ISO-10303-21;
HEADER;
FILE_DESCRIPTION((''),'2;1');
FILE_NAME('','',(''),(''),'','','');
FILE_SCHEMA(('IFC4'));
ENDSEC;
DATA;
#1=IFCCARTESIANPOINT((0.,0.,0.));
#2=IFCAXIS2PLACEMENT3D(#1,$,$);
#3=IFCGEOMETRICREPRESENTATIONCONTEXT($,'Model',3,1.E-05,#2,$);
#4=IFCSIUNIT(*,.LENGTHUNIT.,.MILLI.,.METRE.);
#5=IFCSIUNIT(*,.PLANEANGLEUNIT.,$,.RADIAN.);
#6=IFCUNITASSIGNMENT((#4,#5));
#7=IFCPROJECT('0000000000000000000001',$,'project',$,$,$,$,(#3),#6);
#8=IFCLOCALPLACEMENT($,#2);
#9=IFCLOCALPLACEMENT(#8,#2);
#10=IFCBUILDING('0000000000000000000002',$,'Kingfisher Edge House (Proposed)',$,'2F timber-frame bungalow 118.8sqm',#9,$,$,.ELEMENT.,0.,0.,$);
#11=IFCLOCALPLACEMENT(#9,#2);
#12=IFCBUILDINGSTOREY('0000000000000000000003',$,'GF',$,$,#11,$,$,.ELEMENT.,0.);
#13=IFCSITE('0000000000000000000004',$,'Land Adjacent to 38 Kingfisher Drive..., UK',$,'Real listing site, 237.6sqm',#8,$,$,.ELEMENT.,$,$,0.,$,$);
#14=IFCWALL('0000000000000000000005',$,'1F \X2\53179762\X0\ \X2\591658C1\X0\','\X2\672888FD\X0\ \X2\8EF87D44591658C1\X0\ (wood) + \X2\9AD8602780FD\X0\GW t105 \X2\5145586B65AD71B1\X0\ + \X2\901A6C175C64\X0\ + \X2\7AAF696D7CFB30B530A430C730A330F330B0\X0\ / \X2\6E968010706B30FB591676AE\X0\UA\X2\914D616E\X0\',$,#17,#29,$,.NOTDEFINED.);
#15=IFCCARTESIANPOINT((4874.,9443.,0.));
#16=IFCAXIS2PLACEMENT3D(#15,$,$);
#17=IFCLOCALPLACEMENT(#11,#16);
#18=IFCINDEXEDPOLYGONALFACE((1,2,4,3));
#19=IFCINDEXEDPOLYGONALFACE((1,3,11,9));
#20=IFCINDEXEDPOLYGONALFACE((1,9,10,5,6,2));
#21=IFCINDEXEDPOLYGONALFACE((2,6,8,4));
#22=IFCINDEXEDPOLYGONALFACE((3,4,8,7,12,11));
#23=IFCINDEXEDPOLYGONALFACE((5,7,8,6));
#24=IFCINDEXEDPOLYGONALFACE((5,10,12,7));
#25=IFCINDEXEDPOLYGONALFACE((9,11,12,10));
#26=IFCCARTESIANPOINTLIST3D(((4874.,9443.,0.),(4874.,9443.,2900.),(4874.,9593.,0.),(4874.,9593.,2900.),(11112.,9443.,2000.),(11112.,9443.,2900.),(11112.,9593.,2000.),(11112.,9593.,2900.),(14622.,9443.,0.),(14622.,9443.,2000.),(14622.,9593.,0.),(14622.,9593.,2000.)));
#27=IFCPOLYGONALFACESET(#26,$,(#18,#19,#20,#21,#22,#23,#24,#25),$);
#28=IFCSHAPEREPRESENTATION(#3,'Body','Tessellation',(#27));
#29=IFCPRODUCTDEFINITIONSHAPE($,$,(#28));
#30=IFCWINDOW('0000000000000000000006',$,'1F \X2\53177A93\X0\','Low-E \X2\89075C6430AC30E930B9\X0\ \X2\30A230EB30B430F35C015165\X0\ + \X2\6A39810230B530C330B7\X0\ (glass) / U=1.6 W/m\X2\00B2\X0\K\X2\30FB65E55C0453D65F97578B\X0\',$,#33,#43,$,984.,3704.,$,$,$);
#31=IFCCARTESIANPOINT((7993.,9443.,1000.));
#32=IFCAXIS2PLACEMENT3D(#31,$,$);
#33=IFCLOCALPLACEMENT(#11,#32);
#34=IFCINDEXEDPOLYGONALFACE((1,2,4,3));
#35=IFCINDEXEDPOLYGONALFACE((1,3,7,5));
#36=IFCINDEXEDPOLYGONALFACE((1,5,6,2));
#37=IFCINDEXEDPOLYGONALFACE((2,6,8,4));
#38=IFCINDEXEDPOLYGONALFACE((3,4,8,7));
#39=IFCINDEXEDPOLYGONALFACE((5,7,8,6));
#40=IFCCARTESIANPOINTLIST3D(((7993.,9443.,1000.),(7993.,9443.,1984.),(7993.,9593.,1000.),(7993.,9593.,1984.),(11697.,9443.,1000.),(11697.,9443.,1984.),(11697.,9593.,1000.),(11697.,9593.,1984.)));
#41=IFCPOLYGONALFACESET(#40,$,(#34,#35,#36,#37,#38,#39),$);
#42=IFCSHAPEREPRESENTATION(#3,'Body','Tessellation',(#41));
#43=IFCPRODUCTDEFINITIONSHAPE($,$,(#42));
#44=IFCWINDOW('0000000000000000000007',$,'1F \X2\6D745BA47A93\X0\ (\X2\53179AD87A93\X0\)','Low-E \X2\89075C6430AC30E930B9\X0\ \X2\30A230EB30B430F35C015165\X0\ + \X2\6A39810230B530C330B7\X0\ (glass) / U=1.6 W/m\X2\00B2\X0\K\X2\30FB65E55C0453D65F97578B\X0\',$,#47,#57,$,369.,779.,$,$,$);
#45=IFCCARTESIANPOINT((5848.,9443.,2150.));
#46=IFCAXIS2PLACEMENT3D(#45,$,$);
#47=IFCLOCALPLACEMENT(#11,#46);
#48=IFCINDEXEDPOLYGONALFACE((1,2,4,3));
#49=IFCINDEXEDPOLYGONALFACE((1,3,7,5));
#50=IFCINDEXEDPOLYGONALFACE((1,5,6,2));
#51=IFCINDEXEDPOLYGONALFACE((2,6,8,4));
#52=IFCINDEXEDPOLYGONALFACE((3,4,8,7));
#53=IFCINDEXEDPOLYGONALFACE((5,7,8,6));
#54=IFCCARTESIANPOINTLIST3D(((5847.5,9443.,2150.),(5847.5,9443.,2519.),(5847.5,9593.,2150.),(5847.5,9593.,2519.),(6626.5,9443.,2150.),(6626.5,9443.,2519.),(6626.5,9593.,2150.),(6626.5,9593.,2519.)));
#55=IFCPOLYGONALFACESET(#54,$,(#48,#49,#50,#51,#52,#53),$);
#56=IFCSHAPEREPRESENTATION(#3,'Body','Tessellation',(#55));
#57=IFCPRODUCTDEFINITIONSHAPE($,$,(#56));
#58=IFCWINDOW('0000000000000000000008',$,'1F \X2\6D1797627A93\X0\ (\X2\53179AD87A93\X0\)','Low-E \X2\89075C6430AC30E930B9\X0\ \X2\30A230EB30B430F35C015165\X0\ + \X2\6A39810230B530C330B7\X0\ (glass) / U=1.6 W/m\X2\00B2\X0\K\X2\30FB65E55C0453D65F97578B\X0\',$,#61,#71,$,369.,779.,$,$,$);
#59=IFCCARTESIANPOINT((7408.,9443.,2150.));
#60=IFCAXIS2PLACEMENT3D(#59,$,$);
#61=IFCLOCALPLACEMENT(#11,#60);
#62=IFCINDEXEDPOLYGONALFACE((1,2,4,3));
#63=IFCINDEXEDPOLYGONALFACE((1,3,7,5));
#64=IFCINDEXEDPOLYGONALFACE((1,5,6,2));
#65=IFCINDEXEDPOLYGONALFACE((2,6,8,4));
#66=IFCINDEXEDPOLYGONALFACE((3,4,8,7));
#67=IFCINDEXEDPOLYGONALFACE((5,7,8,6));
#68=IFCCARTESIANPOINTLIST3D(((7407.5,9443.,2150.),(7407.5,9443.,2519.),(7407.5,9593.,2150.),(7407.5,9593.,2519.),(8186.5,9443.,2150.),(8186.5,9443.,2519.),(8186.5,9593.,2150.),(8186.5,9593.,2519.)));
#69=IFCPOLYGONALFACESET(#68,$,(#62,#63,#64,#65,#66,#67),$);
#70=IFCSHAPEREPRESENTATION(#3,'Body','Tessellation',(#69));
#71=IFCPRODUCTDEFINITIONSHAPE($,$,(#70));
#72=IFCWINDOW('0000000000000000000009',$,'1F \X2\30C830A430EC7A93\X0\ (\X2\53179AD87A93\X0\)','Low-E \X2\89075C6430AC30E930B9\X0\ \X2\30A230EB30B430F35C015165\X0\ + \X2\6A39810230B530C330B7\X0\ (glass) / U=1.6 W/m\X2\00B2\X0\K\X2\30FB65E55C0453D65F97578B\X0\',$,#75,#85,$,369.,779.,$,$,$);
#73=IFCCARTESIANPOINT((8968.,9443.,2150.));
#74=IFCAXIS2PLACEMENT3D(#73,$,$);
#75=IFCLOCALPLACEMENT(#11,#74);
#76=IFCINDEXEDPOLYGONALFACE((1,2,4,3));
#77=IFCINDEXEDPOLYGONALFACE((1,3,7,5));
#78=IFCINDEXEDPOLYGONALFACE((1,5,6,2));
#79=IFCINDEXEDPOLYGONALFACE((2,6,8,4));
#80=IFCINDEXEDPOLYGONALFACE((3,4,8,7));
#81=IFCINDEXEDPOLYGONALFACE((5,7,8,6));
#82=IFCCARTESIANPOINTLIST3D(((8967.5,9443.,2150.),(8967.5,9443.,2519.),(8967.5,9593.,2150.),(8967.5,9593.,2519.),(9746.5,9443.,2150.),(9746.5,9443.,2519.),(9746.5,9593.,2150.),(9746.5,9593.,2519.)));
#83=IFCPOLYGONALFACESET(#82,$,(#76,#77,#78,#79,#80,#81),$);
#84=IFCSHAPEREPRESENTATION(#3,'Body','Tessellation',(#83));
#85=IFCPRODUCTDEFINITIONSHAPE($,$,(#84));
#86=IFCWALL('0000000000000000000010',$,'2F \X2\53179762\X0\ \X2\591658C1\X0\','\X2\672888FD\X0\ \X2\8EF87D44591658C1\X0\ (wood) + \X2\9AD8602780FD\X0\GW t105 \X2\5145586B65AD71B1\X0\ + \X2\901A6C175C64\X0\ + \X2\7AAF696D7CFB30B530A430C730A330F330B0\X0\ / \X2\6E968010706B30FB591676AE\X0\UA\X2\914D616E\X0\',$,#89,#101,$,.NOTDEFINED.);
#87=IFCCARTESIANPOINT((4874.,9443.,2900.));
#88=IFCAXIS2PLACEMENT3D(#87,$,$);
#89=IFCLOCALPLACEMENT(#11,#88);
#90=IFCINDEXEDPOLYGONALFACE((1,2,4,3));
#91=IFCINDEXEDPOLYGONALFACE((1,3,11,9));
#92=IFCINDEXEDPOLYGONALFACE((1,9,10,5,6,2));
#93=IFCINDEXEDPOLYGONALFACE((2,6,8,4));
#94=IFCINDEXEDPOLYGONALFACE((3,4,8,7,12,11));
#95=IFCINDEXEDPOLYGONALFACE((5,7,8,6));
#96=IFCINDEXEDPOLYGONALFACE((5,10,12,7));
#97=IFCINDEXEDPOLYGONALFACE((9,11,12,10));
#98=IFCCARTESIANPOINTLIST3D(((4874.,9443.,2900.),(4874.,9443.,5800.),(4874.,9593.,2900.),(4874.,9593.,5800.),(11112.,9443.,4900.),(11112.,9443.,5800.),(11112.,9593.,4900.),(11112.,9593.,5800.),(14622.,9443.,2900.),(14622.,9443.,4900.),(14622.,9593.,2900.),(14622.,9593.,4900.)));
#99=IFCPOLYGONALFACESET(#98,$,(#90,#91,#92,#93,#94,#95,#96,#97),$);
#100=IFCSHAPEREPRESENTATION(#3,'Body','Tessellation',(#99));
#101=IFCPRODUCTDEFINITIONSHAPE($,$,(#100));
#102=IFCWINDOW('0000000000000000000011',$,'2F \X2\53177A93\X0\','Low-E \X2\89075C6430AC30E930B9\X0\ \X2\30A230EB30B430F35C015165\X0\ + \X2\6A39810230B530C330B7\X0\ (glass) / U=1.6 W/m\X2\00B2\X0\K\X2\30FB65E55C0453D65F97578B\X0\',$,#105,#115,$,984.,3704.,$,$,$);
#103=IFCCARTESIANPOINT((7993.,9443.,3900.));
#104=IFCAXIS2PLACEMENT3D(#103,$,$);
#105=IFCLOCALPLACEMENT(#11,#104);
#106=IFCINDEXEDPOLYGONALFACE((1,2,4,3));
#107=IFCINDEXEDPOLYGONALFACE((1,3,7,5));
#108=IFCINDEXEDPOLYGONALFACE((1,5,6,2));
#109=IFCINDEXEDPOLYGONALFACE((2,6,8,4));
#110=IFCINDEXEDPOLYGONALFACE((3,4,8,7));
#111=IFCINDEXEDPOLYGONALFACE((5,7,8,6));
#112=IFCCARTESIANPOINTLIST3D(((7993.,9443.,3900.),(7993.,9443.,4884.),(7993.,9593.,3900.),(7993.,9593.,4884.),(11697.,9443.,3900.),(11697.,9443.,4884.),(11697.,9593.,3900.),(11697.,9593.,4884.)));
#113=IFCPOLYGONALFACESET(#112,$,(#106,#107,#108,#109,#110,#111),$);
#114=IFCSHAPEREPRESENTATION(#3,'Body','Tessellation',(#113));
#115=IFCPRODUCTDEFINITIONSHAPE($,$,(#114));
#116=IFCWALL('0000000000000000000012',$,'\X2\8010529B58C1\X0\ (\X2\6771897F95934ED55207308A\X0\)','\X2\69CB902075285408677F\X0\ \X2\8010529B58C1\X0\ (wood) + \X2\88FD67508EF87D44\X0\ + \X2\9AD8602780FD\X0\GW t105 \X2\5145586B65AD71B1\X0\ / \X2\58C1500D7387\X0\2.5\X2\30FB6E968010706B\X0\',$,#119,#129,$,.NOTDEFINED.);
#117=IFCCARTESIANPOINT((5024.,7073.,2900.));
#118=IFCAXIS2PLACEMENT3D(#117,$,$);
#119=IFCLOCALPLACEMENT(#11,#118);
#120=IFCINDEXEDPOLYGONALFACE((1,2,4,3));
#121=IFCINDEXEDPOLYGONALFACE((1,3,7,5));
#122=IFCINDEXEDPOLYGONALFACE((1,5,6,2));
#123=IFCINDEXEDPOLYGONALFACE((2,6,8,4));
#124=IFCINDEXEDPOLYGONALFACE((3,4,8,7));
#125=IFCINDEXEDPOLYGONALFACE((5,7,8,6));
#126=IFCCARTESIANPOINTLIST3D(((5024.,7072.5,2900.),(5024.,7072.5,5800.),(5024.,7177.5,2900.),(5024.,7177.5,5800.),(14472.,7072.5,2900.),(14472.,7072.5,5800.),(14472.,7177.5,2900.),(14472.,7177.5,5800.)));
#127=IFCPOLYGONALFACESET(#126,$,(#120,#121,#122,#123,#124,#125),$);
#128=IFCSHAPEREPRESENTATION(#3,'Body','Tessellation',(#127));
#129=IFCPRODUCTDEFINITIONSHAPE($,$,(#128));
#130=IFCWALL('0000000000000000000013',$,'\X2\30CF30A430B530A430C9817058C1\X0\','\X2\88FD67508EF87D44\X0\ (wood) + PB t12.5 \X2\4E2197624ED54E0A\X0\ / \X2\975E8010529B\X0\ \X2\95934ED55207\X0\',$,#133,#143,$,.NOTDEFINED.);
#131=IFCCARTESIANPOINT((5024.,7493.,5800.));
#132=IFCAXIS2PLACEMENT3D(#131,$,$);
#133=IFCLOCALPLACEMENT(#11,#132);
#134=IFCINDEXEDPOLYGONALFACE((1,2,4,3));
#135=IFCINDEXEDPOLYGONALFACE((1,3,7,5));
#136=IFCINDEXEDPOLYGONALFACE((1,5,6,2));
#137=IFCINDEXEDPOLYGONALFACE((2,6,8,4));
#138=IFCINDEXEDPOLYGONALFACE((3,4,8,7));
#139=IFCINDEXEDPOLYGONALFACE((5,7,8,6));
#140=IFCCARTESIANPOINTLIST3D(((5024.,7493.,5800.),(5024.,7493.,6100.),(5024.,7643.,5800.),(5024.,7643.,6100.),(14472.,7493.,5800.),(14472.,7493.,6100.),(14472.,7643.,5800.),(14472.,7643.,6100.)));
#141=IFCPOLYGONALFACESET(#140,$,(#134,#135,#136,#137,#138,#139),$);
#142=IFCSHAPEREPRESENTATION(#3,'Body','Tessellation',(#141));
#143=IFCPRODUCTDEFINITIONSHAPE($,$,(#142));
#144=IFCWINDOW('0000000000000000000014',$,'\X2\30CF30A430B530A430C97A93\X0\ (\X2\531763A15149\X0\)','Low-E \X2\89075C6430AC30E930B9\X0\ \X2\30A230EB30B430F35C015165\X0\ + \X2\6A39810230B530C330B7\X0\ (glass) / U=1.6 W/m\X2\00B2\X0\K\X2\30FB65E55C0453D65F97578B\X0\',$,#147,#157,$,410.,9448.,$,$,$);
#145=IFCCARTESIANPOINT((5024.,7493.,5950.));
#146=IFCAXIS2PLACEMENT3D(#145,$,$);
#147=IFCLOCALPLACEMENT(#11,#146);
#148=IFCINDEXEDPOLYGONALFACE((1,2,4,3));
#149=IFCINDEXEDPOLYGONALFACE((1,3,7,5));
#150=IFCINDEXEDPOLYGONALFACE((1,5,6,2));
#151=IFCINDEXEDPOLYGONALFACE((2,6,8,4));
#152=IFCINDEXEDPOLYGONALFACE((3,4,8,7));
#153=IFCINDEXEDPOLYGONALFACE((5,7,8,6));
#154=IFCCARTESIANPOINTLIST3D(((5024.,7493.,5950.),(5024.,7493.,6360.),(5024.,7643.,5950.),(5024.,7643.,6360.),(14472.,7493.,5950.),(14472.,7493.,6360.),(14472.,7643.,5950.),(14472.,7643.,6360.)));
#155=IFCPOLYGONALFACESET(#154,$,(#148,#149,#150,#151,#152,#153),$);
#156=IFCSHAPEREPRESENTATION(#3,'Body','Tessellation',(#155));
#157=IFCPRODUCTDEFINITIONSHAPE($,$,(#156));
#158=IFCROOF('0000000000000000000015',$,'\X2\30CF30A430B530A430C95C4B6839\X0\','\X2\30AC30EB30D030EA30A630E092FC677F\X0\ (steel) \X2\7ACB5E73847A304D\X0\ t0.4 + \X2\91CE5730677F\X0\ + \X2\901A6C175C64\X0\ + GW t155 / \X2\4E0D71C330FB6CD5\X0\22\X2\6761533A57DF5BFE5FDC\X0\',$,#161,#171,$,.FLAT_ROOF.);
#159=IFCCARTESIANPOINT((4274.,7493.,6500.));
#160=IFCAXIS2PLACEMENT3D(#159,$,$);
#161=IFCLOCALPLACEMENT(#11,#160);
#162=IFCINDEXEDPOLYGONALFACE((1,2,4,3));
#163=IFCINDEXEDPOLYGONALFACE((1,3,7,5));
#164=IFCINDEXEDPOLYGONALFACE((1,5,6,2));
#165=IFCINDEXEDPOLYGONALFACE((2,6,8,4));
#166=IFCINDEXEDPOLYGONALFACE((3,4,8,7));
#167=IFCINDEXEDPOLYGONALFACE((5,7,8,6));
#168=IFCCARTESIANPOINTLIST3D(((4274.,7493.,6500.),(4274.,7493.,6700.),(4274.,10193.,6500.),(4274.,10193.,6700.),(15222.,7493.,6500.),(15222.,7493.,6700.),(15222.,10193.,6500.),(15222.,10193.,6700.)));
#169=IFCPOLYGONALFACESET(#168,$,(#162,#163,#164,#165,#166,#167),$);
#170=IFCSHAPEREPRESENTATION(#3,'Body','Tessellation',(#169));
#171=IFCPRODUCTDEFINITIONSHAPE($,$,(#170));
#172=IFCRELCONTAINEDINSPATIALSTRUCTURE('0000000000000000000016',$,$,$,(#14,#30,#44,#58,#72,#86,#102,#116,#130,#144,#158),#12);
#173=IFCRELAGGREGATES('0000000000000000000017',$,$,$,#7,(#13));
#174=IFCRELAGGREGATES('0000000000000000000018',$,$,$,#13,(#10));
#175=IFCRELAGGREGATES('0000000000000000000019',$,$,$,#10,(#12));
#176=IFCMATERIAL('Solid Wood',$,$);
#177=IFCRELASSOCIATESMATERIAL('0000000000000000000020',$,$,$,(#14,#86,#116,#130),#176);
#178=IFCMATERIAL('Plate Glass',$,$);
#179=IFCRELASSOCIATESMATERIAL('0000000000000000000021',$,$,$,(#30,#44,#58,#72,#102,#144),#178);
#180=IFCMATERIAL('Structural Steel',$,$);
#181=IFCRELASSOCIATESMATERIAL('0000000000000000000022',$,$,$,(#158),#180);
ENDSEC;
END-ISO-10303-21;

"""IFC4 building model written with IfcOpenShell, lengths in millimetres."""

from ifc_helpers import new_model, si_unit, frame, frame_2d, origin, place, context, project, spatial, rectangle, extrude, material, element, fill, save


model = new_model("IFC4")

# Units and contexts
model_context = context("Model", 3, precision=1e-05, world=origin())
ifc_project = project(units=[si_unit("LENGTHUNIT", "METRE", prefix="MILLI"), si_unit("PLANEANGLEUNIT", "RADIAN")], contexts=[model_context])

# Site, building, storey
site_placement = place(None, origin())
site = spatial("IfcSite", under=ifc_project, at=site_placement, Name="Land Adjacent to 38 Kingfisher Drive..., UK", ObjectType="Real listing site, 237.6sqm", CompositionType="ELEMENT", RefElevation=0.0)
building_placement = place(site_placement, origin())
building = spatial("IfcBuilding", under=site, at=building_placement, Name="Kingfisher Edge House (Proposed)", ObjectType="2F timber-frame bungalow 118.8sqm", CompositionType="ELEMENT", ElevationOfRefHeight=0.0, ElevationOfTerrain=0.0)
storey_placement = place(building_placement, origin())
storey = spatial("IfcBuildingStorey", under=building, at=storey_placement, Name="GF", CompositionType="ELEMENT", Elevation=0.0)

# Wall, openings, windows
ifc_material_1 = material(Name="Solid Wood")
wall_1_placement = place(storey_placement, frame((4874.0, 9443.0, 0.0)))
wall_1 = element("IfcWall", 1, at=wall_1_placement, inside=storey, material=ifc_material_1, Name="1F 北面 外壁", Description="木製 軸組外壁 (wood) + 高性能GW t105 充填断熱 + 通気層 + 窯業系サイディング / 準耐火・外皮UA配慮", PredefinedType="NOTDEFINED", context=model_context, shape_type="SweptSolid", body=[
    extrude(rectangle(XDim=9748.0, YDim=150.0, at=frame_2d((4874.0, 75.0))), frame((4874.0, 9443.0, 0.0)), (0.0, 0.0, 1.0), 2900.0),
])
opening_1_placement = place(storey_placement, frame((7993.0, 9443.0, 1000.0)))
opening_1 = element("IfcOpeningElement", 2, at=opening_1_placement, cuts=wall_1, PredefinedType="NOTDEFINED", context=model_context, shape_type="SweptSolid", body=[
    extrude(rectangle(XDim=3704.0, YDim=150.0, at=frame_2d((1852.0, 75.0))), frame((7993.0, 9443.0, 1000.0)), (0.0, 0.0, 1.0), 984.0),
])
opening_2_placement = place(storey_placement, frame((5848.0, 9443.0, 2150.0)))
opening_2 = element("IfcOpeningElement", 3, at=opening_2_placement, cuts=wall_1, PredefinedType="NOTDEFINED", context=model_context, shape_type="SweptSolid", body=[
    extrude(rectangle(XDim=779.0, YDim=150.0, at=frame_2d((389.0, 75.0))), frame((5848.0, 9443.0, 2150.0)), (0.0, 0.0, 1.0), 369.0),
])
opening_3_placement = place(storey_placement, frame((7408.0, 9443.0, 2150.0)))
opening_3 = element("IfcOpeningElement", 4, at=opening_3_placement, cuts=wall_1, PredefinedType="NOTDEFINED", context=model_context, shape_type="SweptSolid", body=[
    extrude(rectangle(XDim=779.0, YDim=150.0, at=frame_2d((389.0, 75.0))), frame((7408.0, 9443.0, 2150.0)), (0.0, 0.0, 1.0), 369.0),
])
opening_4_placement = place(storey_placement, frame((8968.0, 9443.0, 2150.0)))
opening_4 = element("IfcOpeningElement", 5, at=opening_4_placement, cuts=wall_1, PredefinedType="NOTDEFINED", context=model_context, shape_type="SweptSolid", body=[
    extrude(rectangle(XDim=779.0, YDim=150.0, at=frame_2d((389.0, 75.0))), frame((8968.0, 9443.0, 2150.0)), (0.0, 0.0, 1.0), 369.0),
])
ifc_material_2 = material(Name="Plate Glass")
window_1_placement = place(storey_placement, frame((7993.0, 9443.0, 1000.0)))
window_1 = element("IfcWindow", 6, at=window_1_placement, inside=storey, material=ifc_material_2, Name="1F 北窓", Description="Low-E 複層ガラス アルゴン封入 + 樹脂サッシ (glass) / U=1.6 W/m²K・日射取得型", OverallHeight=984.0, OverallWidth=3704.0, context=model_context, shape_type="SweptSolid", body=[
    extrude(rectangle(XDim=3704.0, YDim=150.0, at=frame_2d((1852.0, 75.0))), frame((7993.0, 9443.0, 1000.0)), (0.0, 0.0, 1.0), 984.0),
])
fill(opening_1, window_1)
window_2_placement = place(storey_placement, frame((5848.0, 9443.0, 2150.0)))
window_2 = element("IfcWindow", 7, at=window_2_placement, inside=storey, material=ifc_material_2, Name="1F 浴室窓 (北高窓)", Description="Low-E 複層ガラス アルゴン封入 + 樹脂サッシ (glass) / U=1.6 W/m²K・日射取得型", OverallHeight=369.0, OverallWidth=779.0, context=model_context, shape_type="SweptSolid", body=[
    extrude(rectangle(XDim=779.0, YDim=150.0, at=frame_2d((389.0, 75.0))), frame((5848.0, 9443.0, 2150.0)), (0.0, 0.0, 1.0), 369.0),
])
fill(opening_2, window_2)
window_3_placement = place(storey_placement, frame((7408.0, 9443.0, 2150.0)))
window_3 = element("IfcWindow", 8, at=window_3_placement, inside=storey, material=ifc_material_2, Name="1F 洗面窓 (北高窓)", Description="Low-E 複層ガラス アルゴン封入 + 樹脂サッシ (glass) / U=1.6 W/m²K・日射取得型", OverallHeight=369.0, OverallWidth=779.0, context=model_context, shape_type="SweptSolid", body=[
    extrude(rectangle(XDim=779.0, YDim=150.0, at=frame_2d((389.0, 75.0))), frame((7408.0, 9443.0, 2150.0)), (0.0, 0.0, 1.0), 369.0),
])
fill(opening_3, window_3)
window_4_placement = place(storey_placement, frame((8968.0, 9443.0, 2150.0)))
window_4 = element("IfcWindow", 9, at=window_4_placement, inside=storey, material=ifc_material_2, Name="1F トイレ窓 (北高窓)", Description="Low-E 複層ガラス アルゴン封入 + 樹脂サッシ (glass) / U=1.6 W/m²K・日射取得型", OverallHeight=369.0, OverallWidth=779.0, context=model_context, shape_type="SweptSolid", body=[
    extrude(rectangle(XDim=779.0, YDim=150.0, at=frame_2d((389.0, 75.0))), frame((8968.0, 9443.0, 2150.0)), (0.0, 0.0, 1.0), 369.0),
])
fill(opening_4, window_4)

# Wall, opening, window
wall_2_placement = place(storey_placement, frame((4874.0, 9443.0, 2900.0)))
wall_2 = element("IfcWall", 10, at=wall_2_placement, inside=storey, material=ifc_material_1, Name="2F 北面 外壁", Description="木製 軸組外壁 (wood) + 高性能GW t105 充填断熱 + 通気層 + 窯業系サイディング / 準耐火・外皮UA配慮", PredefinedType="NOTDEFINED", context=model_context, shape_type="SweptSolid", body=[
    extrude(rectangle(XDim=9748.0, YDim=150.0, at=frame_2d((4874.0, 75.0))), frame((4874.0, 9443.0, 2900.0)), (0.0, 0.0, 1.0), 2900.0),
])
opening_5_placement = place(storey_placement, frame((7993.0, 9443.0, 3900.0)))
opening_5 = element("IfcOpeningElement", 11, at=opening_5_placement, cuts=wall_2, PredefinedType="NOTDEFINED", context=model_context, shape_type="SweptSolid", body=[
    extrude(rectangle(XDim=3704.0, YDim=150.0, at=frame_2d((1852.0, 75.0))), frame((7993.0, 9443.0, 3900.0)), (0.0, 0.0, 1.0), 984.0),
])
window_5_placement = place(storey_placement, frame((7993.0, 9443.0, 3900.0)))
window_5 = element("IfcWindow", 12, at=window_5_placement, inside=storey, material=ifc_material_2, Name="2F 北窓", Description="Low-E 複層ガラス アルゴン封入 + 樹脂サッシ (glass) / U=1.6 W/m²K・日射取得型", OverallHeight=984.0, OverallWidth=3704.0, context=model_context, shape_type="SweptSolid", body=[
    extrude(rectangle(XDim=3704.0, YDim=150.0, at=frame_2d((1852.0, 75.0))), frame((7993.0, 9443.0, 3900.0)), (0.0, 0.0, 1.0), 984.0),
])
fill(opening_5, window_5)

# Wall
wall_3_placement = place(storey_placement, frame((5024.0, 7073.0, 2900.0)))
element("IfcWall", 13, at=wall_3_placement, inside=storey, material=ifc_material_1, Name="耐力壁 (東西間仕切り)", Description="構造用合板 耐力壁 (wood) + 製材軸組 + 高性能GW t105 充填断熱 / 壁倍率2.5・準耐火", PredefinedType="NOTDEFINED", context=model_context, shape_type="SweptSolid", body=[
    extrude(rectangle(XDim=9448.0, YDim=105.0, at=frame_2d((4724.0, 52.0))), frame((5024.0, 7073.0, 2900.0)), (0.0, 0.0, 1.0), 2900.0),
])

# Wall, opening, window
wall_4_placement = place(storey_placement, frame((5024.0, 7493.0, 5800.0)))
wall_4 = element("IfcWall", 14, at=wall_4_placement, inside=storey, material=ifc_material_1, Name="ハイサイド腰壁", Description="製材軸組 (wood) + PB t12.5 両面仕上 / 非耐力 間仕切", PredefinedType="NOTDEFINED", context=model_context, shape_type="SweptSolid", body=[
    extrude(rectangle(XDim=9448.0, YDim=150.0, at=frame_2d((4724.0, 75.0))), frame((5024.0, 7493.0, 5800.0)), (0.0, 0.0, 1.0), 700.0),
])
opening_6_placement = place(storey_placement, frame((5024.0, 7493.0, 5950.0)))
opening_6 = element("IfcOpeningElement", 15, at=opening_6_placement, cuts=wall_4, PredefinedType="NOTDEFINED", context=model_context, shape_type="SweptSolid", body=[
    extrude(rectangle(XDim=9448.0, YDim=150.0, at=frame_2d((4724.0, 75.0))), frame((5024.0, 7493.0, 5950.0)), (0.0, 0.0, 1.0), 410.0),
])
window_6_placement = place(storey_placement, frame((5024.0, 7493.0, 5950.0)))
window_6 = element("IfcWindow", 16, at=window_6_placement, inside=storey, material=ifc_material_2, Name="ハイサイド窓 (北採光)", Description="Low-E 複層ガラス アルゴン封入 + 樹脂サッシ (glass) / U=1.6 W/m²K・日射取得型", OverallHeight=410.0, OverallWidth=9448.0, context=model_context, shape_type="SweptSolid", body=[
    extrude(rectangle(XDim=9448.0, YDim=150.0, at=frame_2d((4724.0, 75.0))), frame((5024.0, 7493.0, 5950.0)), (0.0, 0.0, 1.0), 410.0),
])
fill(opening_6, window_6)

# Roof
ifc_material_3 = material(Name="Structural Steel")
roof_placement = place(storey_placement, frame((4274.0, 7493.0, 6500.0)))
element("IfcRoof", 17, at=roof_placement, inside=storey, material=ifc_material_3, Name="ハイサイド屋根", Description="ガルバリウム鋼板 (steel) 立平葺き t0.4 + 野地板 + 通気層 + GW t155 / 不燃・法22条区域対応", PredefinedType="FLAT_ROOF", context=model_context, shape_type="SweptSolid", body=[
    extrude(rectangle(XDim=10948.0, YDim=2700.0, at=frame_2d((5474.0, 1350.0))), frame((4274.0, 7493.0, 6500.0)), (0.0, 0.0, 1.0), 200.0),
])

save(model, "model.ifc")
